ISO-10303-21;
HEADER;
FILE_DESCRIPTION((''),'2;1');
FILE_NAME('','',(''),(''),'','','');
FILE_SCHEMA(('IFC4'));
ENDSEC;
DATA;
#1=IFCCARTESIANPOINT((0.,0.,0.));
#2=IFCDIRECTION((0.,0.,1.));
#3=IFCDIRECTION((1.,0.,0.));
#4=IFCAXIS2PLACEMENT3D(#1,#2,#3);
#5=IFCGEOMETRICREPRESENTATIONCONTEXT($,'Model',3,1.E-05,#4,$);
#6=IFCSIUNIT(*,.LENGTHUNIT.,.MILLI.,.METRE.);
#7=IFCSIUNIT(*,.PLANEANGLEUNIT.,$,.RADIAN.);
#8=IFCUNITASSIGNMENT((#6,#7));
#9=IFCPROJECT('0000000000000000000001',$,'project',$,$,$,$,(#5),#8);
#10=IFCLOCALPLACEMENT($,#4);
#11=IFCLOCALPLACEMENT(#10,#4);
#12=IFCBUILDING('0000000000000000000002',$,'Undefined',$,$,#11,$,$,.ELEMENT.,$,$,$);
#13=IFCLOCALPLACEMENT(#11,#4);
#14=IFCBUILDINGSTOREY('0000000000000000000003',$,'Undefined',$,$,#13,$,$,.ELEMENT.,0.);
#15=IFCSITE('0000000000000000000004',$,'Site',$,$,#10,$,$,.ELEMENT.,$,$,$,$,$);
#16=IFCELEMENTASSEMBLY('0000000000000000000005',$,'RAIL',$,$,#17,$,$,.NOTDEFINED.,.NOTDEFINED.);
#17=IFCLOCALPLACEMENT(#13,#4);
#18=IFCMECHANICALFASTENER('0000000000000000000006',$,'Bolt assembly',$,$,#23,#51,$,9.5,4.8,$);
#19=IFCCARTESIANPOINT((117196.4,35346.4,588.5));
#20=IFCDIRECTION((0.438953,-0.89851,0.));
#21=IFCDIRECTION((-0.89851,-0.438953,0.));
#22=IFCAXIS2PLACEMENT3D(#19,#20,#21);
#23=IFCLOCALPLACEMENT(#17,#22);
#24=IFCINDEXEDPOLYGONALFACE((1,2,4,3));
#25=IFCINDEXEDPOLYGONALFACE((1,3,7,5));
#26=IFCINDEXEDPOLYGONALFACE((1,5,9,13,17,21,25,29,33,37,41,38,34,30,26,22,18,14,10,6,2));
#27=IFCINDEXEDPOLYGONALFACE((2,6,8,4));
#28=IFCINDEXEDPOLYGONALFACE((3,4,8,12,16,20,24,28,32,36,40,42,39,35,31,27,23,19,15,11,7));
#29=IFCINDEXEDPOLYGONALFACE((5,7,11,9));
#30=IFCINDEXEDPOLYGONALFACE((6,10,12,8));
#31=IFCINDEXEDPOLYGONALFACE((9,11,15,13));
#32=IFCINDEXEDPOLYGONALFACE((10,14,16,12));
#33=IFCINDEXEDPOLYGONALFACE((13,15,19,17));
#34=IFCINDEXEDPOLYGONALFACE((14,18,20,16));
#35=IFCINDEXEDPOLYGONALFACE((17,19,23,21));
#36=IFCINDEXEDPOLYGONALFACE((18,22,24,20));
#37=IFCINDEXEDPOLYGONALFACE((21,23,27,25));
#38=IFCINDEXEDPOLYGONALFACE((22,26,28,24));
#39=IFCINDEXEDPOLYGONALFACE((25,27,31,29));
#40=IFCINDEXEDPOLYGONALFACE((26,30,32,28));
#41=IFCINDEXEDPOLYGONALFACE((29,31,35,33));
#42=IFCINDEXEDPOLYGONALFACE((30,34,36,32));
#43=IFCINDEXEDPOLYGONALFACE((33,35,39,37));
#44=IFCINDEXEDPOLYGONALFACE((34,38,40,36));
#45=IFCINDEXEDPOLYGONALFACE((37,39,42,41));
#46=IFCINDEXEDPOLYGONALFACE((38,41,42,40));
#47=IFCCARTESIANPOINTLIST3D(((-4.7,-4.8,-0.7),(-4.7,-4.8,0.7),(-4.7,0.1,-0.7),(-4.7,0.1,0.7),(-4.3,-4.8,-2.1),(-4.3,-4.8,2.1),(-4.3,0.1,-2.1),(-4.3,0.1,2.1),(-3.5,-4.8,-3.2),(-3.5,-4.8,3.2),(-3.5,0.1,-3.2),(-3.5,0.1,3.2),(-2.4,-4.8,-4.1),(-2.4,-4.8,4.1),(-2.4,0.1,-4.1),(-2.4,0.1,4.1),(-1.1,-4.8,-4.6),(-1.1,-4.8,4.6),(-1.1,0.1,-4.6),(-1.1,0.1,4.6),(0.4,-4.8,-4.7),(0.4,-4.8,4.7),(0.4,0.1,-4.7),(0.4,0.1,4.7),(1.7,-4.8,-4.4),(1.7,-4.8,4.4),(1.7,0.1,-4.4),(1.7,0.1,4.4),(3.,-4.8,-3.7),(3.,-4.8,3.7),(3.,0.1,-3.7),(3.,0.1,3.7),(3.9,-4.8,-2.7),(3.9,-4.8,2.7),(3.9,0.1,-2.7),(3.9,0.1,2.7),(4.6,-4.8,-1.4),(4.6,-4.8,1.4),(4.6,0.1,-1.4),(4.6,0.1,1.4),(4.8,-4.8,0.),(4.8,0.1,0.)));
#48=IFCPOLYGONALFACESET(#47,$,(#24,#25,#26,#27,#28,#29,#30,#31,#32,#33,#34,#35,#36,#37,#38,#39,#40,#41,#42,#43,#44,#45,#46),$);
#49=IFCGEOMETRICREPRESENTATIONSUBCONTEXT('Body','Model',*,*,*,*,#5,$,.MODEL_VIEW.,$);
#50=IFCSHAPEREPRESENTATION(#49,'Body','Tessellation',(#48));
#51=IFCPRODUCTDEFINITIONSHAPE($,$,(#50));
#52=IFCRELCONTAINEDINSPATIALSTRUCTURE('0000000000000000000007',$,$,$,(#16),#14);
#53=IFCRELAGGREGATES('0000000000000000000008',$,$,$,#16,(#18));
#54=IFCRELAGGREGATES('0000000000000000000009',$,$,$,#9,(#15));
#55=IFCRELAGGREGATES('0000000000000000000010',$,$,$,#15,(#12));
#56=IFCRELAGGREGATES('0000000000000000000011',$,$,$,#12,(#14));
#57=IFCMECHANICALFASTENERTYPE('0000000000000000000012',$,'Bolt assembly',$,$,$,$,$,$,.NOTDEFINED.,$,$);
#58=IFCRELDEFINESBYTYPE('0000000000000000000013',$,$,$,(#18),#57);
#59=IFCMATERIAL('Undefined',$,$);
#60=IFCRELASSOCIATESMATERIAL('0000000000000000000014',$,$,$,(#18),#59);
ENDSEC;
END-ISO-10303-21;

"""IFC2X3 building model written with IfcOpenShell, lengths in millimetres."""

from ifc_helpers import new_model, si_unit, frame, origin_with_axes, origin_2d_with_axis, place, context, subcontext, project, spatial, circle, extrude, source, transform, mapped, material, type_object, element, aggregate, save


model = new_model("IFC2X3")

# Units and contexts
model_context = context("Model", 3, precision=1e-05, world=origin_with_axes())
body_context = subcontext(model_context, "Body", "Model", "MODEL_VIEW")
ifc_project = project(units=[si_unit("LENGTHUNIT", "METRE", prefix="MILLI"), si_unit("PLANEANGLEUNIT", "RADIAN")], contexts=[model_context])

# Site, building, storey
site_placement = place(None, origin_with_axes())
site = spatial("IfcSite", under=ifc_project, at=site_placement, Name="Site", CompositionType="ELEMENT")
building_placement = place(site_placement, origin_with_axes())
building = spatial("IfcBuilding", under=site, at=building_placement, Name="Undefined", CompositionType="ELEMENT")
storey_placement = place(building_placement, origin_with_axes())
storey = spatial("IfcBuildingStorey", under=building, at=storey_placement, Name="Undefined", CompositionType="ELEMENT", Elevation=0.0)

# Element assembly
assembly_1_placement = place(storey_placement, origin_with_axes())
assembly_1 = element("IfcElementAssembly", 1, at=assembly_1_placement, inside=storey, Name="RAIL", AssemblyPlace="NOTDEFINED", PredefinedType="NOTDEFINED")

# Mechanical fastener
ifc_material_1 = material(Name="Undefined")
mechanical_fastener_type = type_object("IfcMechanicalFastenerType", Name="Bolt assembly")
shared_shape_1 = source(origin_with_axes(), body_context, "Body", "SweptSolid", [
    extrude(circle(Radius=4.8, at=origin_2d_with_axis()), frame((0.0, -4.8, 0.0), z_axis=(0.0, 1.0, 0.0), x_axis=(1.0, 0.0, 0.0)), (0.0, 0.0, 1.0), 4.9),
])
mechanical_fastener_1_placement = place(assembly_1_placement, frame((117196.4, 35346.4, 588.5), z_axis=(0.438953, -0.89851, 0.0), x_axis=(-0.89851, -0.438953, 0.0)))
mechanical_fastener_1 = element("IfcMechanicalFastener", 2, at=mechanical_fastener_1_placement, type_object=mechanical_fastener_type, material=ifc_material_1, Name="Bolt assembly", NominalDiameter=9.5, NominalLength=4.8, context=body_context, shape_type="MappedRepresentation", body=[
    mapped(shared_shape_1, transform((0.0, 0.0, 0.0))),
])
aggregate(assembly_1, [mechanical_fastener_1])

save(model, "model.ifc")
